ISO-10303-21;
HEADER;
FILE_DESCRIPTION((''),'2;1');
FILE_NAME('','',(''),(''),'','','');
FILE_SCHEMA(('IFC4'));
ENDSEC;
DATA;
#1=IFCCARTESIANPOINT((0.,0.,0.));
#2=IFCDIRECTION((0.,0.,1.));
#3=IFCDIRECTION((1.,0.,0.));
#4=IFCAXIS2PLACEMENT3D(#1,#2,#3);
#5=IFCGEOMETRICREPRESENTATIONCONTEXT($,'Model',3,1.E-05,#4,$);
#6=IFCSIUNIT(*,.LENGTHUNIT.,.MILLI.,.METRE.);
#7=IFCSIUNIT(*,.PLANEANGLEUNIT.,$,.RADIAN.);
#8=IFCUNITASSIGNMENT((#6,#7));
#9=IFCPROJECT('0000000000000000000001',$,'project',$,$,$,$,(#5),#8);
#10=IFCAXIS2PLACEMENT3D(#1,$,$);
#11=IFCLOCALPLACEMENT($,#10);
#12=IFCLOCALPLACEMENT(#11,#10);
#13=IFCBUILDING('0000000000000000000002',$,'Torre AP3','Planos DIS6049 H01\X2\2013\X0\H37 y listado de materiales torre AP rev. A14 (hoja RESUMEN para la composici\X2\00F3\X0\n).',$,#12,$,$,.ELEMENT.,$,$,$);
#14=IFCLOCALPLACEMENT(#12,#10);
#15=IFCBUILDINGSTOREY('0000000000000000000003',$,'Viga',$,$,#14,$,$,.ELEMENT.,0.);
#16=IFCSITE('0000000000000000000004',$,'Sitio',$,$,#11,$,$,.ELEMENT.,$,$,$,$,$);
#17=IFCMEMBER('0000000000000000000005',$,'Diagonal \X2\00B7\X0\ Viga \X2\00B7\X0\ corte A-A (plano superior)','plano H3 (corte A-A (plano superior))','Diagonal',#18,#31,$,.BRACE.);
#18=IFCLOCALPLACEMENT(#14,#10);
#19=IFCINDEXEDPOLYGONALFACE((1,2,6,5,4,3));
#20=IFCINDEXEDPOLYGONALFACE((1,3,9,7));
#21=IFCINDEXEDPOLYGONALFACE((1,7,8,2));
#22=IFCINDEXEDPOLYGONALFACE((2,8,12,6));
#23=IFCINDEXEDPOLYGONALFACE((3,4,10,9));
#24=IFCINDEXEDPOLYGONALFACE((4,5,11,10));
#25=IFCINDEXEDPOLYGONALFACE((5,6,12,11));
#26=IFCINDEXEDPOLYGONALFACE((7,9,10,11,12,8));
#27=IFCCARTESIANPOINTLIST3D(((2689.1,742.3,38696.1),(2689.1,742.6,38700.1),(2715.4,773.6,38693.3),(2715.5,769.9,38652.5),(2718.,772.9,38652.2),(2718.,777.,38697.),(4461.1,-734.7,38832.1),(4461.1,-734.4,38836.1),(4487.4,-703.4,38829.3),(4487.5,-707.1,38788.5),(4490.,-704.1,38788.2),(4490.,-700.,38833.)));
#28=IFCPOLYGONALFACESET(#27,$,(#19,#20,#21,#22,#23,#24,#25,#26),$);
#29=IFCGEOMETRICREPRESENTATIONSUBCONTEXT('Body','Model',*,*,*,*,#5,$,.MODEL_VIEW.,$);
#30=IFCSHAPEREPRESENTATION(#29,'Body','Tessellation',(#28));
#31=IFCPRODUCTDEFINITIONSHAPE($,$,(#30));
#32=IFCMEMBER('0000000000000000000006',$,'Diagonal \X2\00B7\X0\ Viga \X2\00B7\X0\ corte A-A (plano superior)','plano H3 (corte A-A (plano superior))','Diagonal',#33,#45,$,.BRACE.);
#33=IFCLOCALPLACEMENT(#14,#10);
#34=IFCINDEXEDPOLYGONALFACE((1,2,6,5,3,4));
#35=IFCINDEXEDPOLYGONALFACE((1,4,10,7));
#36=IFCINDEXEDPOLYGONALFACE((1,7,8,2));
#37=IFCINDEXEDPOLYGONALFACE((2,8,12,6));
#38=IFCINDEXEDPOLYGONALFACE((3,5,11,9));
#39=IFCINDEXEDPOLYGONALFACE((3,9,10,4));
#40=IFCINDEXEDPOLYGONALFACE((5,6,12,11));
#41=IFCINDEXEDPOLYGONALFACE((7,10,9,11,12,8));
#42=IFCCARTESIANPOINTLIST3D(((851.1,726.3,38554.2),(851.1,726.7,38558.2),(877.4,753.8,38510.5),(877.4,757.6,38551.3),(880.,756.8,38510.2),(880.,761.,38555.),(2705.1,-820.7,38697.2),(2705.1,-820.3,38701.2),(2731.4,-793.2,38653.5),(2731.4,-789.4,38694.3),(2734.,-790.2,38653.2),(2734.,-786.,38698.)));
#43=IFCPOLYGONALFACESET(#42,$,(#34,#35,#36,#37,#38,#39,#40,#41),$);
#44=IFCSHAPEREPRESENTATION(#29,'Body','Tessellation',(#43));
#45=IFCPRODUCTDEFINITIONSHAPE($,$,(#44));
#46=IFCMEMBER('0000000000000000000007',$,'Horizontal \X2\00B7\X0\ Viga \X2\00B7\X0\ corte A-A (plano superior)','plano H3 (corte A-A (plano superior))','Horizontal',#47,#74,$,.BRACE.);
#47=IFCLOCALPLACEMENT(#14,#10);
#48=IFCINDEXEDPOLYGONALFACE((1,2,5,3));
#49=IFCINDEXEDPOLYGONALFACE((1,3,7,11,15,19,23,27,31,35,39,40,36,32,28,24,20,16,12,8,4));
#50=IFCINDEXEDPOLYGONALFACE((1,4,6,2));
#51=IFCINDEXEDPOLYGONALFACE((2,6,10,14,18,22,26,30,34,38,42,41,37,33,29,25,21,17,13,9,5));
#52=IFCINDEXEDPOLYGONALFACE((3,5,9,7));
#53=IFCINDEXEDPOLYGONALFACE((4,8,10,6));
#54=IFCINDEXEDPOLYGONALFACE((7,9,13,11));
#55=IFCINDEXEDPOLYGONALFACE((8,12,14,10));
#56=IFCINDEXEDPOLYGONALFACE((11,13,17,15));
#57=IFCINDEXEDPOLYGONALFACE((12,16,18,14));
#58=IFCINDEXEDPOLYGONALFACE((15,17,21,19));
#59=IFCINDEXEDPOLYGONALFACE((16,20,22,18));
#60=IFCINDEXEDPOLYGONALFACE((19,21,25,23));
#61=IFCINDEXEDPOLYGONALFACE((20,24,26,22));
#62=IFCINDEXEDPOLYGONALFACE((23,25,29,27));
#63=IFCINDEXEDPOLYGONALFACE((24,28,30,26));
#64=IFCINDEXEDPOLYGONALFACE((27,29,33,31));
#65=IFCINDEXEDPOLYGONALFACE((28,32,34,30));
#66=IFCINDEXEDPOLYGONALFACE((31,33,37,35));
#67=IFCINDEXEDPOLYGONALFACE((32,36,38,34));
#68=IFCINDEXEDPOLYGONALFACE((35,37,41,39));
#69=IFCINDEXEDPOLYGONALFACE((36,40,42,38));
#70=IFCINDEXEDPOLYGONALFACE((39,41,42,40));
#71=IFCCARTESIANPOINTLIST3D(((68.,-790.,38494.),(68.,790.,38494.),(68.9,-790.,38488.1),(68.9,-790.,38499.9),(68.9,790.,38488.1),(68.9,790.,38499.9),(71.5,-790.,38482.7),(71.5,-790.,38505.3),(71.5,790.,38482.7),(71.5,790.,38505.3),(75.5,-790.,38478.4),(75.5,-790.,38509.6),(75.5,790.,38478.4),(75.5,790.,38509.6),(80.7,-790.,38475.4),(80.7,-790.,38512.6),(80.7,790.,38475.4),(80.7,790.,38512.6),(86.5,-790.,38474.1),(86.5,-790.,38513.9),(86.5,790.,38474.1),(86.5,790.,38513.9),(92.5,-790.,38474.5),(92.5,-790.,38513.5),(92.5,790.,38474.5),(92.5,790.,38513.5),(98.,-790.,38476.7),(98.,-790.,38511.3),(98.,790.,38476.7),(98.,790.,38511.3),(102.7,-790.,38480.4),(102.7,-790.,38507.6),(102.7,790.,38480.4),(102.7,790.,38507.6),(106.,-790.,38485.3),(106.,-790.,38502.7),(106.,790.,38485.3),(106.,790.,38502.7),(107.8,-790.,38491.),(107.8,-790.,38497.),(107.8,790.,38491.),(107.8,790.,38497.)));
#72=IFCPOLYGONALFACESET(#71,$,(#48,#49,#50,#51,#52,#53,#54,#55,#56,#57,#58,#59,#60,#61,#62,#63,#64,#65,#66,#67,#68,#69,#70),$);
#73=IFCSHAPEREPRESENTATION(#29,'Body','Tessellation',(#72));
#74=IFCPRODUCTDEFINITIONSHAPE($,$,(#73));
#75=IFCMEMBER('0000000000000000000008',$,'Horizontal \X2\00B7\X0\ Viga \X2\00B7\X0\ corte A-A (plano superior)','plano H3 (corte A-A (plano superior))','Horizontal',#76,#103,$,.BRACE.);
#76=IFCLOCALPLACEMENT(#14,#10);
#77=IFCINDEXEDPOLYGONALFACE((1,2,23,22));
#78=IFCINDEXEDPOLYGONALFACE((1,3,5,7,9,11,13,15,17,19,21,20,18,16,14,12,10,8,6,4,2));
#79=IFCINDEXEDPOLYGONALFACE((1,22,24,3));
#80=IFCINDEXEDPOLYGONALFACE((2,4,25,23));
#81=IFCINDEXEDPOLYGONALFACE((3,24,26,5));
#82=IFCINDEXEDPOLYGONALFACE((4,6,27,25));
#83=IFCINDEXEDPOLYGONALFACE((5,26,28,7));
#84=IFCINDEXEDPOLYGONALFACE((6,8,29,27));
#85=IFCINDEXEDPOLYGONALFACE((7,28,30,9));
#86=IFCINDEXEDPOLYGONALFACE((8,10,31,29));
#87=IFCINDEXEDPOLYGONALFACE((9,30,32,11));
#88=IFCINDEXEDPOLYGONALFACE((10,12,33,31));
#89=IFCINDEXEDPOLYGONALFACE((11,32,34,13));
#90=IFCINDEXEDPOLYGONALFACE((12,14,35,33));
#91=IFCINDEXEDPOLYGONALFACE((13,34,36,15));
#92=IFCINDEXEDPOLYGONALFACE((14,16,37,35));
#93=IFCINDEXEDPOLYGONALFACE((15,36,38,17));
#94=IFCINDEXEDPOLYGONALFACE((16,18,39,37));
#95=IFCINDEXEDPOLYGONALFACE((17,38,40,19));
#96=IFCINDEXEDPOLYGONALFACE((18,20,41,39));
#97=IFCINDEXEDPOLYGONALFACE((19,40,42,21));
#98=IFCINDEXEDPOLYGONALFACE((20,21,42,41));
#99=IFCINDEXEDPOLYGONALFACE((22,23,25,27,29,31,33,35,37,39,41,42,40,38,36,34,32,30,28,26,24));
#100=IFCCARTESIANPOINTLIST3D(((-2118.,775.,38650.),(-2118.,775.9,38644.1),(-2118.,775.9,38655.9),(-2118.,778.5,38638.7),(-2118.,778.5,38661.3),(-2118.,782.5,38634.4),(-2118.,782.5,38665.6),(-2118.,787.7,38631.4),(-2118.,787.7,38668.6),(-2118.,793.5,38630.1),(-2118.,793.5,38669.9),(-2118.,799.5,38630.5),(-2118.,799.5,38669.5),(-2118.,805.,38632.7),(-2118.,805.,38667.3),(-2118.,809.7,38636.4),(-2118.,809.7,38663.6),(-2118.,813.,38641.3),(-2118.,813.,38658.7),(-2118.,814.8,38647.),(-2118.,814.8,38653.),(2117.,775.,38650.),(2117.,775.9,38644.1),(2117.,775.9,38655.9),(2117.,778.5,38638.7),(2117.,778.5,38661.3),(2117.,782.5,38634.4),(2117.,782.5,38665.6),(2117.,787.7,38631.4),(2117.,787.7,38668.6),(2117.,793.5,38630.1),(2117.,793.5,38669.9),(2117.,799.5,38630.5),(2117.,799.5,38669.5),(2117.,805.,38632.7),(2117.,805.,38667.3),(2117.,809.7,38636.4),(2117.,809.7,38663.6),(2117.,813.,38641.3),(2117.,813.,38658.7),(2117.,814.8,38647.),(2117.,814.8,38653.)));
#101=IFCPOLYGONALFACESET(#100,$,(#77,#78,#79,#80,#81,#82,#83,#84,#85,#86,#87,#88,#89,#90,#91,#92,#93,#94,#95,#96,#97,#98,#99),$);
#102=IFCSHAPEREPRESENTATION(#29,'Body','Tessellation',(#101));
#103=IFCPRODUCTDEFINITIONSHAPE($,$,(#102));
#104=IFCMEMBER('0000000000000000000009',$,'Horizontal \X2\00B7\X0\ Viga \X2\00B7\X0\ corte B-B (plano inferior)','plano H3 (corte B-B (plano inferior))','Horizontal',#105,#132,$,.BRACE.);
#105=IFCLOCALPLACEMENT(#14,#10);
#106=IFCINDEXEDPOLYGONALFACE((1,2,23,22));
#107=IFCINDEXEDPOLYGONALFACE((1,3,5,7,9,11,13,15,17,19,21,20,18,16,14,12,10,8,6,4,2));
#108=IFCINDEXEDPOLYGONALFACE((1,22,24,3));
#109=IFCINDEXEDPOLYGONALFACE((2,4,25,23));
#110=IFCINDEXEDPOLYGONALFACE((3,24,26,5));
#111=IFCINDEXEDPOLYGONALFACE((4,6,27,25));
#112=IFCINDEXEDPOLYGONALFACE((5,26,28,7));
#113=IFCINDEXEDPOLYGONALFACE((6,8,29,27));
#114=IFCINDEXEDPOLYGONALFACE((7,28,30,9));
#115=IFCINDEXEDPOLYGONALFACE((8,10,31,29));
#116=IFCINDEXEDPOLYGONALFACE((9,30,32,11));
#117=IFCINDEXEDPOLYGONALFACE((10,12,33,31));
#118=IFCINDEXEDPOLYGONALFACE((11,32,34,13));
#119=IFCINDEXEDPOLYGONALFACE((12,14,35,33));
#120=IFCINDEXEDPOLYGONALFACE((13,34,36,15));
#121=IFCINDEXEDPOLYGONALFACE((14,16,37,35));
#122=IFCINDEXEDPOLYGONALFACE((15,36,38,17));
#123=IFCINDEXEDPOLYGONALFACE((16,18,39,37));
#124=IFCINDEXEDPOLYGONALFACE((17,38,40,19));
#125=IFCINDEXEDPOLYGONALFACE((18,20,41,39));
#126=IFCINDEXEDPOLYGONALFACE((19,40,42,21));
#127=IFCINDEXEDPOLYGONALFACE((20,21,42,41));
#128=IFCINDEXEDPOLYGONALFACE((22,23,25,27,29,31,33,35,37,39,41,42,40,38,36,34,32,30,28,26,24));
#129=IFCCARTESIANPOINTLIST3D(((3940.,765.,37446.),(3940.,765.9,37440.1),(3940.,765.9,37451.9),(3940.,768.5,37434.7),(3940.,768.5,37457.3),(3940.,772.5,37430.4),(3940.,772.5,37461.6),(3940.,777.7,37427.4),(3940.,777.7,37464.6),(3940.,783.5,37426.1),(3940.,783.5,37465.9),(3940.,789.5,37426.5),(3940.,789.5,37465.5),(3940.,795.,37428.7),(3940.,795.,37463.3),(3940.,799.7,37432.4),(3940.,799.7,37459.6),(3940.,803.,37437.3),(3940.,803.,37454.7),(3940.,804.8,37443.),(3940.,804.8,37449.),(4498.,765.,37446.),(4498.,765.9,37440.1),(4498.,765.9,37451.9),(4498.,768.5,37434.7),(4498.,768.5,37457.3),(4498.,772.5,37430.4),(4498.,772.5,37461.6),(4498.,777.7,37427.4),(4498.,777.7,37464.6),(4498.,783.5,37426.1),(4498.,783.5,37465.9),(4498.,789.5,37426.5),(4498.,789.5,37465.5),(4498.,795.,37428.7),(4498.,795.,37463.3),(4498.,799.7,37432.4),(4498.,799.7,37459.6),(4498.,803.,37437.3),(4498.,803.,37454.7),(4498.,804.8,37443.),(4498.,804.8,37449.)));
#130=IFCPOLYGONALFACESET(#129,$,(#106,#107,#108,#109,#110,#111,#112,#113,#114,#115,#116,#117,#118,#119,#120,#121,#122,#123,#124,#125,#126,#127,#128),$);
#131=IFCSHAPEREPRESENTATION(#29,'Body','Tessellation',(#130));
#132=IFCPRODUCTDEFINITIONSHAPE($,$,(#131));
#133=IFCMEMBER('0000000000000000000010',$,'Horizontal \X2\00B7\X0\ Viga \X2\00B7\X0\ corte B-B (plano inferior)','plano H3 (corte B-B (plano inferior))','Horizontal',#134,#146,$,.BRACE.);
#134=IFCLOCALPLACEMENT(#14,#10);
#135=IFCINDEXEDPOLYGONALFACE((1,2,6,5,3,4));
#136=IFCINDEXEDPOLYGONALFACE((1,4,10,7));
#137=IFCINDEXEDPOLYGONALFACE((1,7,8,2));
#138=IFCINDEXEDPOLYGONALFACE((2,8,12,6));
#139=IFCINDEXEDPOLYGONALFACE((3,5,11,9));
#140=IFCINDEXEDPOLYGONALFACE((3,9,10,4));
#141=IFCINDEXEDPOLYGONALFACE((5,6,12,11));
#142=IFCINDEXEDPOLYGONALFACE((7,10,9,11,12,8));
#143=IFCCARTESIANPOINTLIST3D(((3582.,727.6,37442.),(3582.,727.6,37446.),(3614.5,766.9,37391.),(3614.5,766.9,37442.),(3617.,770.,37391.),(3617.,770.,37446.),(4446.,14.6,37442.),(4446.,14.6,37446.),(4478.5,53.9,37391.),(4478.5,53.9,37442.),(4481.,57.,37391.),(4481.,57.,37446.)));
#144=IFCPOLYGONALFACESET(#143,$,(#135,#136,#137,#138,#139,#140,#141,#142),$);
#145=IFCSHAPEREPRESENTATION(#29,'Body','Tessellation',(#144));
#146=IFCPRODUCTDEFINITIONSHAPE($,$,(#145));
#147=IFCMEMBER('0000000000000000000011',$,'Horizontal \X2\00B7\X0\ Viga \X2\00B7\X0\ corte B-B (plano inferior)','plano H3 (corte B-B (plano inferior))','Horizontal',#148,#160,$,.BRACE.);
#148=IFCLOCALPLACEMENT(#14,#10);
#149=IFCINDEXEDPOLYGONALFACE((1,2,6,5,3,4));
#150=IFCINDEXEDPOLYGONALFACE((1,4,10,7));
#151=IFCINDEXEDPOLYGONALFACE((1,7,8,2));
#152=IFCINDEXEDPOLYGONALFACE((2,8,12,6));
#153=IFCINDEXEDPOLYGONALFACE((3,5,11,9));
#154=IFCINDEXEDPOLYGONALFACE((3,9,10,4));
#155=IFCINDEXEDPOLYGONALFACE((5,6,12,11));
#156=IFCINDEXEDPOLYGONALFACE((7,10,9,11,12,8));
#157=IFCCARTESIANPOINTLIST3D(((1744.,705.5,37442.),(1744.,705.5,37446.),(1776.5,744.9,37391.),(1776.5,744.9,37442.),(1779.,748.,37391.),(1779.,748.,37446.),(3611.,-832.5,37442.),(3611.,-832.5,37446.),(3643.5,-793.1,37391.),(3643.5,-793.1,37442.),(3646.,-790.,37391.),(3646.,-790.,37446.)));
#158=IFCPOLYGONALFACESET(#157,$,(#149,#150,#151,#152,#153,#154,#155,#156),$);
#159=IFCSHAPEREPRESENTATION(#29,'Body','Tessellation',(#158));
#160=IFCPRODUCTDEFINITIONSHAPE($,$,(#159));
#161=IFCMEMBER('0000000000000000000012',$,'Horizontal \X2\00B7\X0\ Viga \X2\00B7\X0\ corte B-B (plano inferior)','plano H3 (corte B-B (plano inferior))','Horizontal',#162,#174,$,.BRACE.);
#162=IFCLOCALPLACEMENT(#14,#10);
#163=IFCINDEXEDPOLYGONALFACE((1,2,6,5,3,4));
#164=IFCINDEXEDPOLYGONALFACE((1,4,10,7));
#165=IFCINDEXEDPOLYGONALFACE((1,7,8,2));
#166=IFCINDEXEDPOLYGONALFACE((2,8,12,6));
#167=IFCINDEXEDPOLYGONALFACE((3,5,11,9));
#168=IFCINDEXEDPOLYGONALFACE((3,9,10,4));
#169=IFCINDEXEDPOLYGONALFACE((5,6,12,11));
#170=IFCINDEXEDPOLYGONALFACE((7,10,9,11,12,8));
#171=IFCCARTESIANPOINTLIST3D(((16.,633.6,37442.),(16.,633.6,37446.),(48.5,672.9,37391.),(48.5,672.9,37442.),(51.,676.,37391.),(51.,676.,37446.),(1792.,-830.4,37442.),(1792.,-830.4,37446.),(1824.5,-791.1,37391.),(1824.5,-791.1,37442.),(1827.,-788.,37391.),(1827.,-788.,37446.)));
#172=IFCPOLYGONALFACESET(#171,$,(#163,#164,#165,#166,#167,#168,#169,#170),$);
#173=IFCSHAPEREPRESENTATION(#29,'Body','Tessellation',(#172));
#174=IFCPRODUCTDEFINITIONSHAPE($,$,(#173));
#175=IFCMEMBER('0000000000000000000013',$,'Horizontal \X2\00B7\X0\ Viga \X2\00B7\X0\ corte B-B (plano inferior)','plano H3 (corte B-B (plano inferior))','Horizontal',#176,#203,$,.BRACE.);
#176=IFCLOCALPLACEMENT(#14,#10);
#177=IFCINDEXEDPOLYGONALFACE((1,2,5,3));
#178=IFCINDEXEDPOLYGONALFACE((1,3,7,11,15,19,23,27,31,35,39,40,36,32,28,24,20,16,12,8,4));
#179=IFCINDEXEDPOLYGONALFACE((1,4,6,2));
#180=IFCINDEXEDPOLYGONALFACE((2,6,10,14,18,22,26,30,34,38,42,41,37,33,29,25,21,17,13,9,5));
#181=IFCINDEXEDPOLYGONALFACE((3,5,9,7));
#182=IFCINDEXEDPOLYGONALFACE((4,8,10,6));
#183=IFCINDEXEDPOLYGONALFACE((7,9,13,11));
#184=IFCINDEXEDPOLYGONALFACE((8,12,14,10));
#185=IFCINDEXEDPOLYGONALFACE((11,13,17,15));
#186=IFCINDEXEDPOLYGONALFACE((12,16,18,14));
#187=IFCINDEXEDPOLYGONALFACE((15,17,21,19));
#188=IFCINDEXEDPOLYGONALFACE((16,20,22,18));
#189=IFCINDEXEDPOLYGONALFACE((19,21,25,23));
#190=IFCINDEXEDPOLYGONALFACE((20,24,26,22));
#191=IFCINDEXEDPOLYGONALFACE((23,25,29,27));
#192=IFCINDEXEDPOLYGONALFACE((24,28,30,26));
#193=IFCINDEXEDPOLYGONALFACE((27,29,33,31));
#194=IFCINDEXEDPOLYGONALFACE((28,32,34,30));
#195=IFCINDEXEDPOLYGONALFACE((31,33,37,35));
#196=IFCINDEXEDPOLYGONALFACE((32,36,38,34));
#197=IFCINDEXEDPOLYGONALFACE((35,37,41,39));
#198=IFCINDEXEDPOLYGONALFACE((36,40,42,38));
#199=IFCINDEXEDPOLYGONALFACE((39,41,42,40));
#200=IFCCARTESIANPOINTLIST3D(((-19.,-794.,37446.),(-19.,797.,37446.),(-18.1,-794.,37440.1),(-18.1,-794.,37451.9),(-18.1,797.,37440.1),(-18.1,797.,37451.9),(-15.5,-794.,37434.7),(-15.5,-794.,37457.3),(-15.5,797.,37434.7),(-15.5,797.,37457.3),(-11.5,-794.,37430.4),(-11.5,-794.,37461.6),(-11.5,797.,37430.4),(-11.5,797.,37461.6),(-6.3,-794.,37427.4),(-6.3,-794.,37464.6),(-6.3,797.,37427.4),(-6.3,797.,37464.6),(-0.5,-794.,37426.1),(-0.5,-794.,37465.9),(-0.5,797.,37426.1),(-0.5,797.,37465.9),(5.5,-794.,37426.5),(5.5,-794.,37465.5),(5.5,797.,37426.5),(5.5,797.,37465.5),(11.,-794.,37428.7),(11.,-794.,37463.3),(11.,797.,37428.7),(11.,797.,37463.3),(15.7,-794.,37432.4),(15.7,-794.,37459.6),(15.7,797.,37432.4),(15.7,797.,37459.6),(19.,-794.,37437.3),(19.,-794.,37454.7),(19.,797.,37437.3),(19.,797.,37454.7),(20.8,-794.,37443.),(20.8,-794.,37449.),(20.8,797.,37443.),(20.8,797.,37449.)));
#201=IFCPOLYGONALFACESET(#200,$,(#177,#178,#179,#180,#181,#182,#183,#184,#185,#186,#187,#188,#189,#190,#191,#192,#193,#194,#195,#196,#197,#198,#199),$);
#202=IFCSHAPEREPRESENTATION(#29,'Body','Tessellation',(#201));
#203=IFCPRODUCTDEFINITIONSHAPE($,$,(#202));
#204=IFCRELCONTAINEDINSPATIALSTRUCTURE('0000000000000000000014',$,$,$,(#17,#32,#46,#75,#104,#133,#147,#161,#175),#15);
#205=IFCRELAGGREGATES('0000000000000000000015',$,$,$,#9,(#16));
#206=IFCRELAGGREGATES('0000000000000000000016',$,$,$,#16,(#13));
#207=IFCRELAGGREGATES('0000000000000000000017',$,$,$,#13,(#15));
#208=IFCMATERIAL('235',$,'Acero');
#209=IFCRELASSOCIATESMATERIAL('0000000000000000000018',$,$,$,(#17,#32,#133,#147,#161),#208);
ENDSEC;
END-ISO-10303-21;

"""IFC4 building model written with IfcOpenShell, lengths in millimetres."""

from ifc_helpers import new_model, si_unit, frame, frame_2d, origin, origin_with_axes, place, context, subcontext, project, spatial, circle, l_section, extrude, material, element, save


model = new_model("IFC4")

# Units and contexts
model_context = context("Model", 3, precision=1e-05, world=origin_with_axes())
body_context = subcontext(model_context, "Body", "Model", "MODEL_VIEW")
ifc_project = project(units=[si_unit("LENGTHUNIT", "METRE", prefix="MILLI"), si_unit("PLANEANGLEUNIT", "RADIAN")], contexts=[model_context])

# Site, building, storey
site_placement = place(None, origin())
site = spatial("IfcSite", under=ifc_project, at=site_placement, Name="Sitio", CompositionType="ELEMENT")
building_placement = place(site_placement, origin())
building = spatial("IfcBuilding", under=site, at=building_placement, Name="Torre AP3", Description="Planos DIS6049 H01–H37 y listado de materiales torre AP rev. A14 (hoja RESUMEN para la composición).", CompositionType="ELEMENT")
storey_placement = place(building_placement, origin())
storey = spatial("IfcBuildingStorey", under=building, at=storey_placement, Name="Viga", CompositionType="ELEMENT", Elevation=0.0)

# Members
ifc_material = material(Name="235", Category="Acero")
member_1_placement = place(storey_placement, frame((2718.0, 777.0, 38697.0), z_axis=(0.766819, -0.63916, 0.058853), x_axis=(-0.641863, -0.763726, 0.06881)))
element("IfcMember", 1, at=member_1_placement, inside=storey, material=ifc_material, Name="Diagonal · Viga · corte A-A (plano superior)", Description="plano H3 (corte A-A (plano superior))", ObjectType="Diagonal", PredefinedType="BRACE", context=body_context, shape_type="SweptSolid", body=[
    extrude(l_section(Depth=45.0, Width=45.0, Thickness=4.0, at=frame_2d((22.5, 22.5))), None, (0.0, 0.0, 1.0), 2310.8),
])
member_2_placement = place(storey_placement, frame((880.0, 761.0, 38555.0), z_axis=(0.766471, -0.639553, 0.059118), x_axis=(-0.642279, -0.763125, 0.071545)))
element("IfcMember", 2, at=member_2_placement, inside=storey, material=ifc_material, Name="Diagonal · Viga · corte A-A (plano superior)", Description="plano H3 (corte A-A (plano superior))", ObjectType="Diagonal", PredefinedType="BRACE", context=body_context, shape_type="SweptSolid", body=[
    extrude(l_section(Depth=45.0, Width=45.0, Thickness=4.0, at=frame_2d((22.5, 22.5))), None, (0.0, 0.0, 1.0), 2418.9),
])
member_3_placement = place(storey_placement, frame((88.0, 790.0, 38494.0), z_axis=(0.0, -1.0, 0.0), x_axis=(-1.0, 0.0, 0.0)))
element("IfcMember", 3, at=member_3_placement, inside=storey, Name="Horizontal · Viga · corte A-A (plano superior)", Description="plano H3 (corte A-A (plano superior))", ObjectType="Horizontal", PredefinedType="BRACE", context=body_context, shape_type="SweptSolid", body=[
    extrude(circle(Radius=20.0), None, (0.0, 0.0, 1.0), 1580.0),
])
member_4_placement = place(storey_placement, frame((2117.0, 795.0, 38650.0), z_axis=(-1.0, 0.0, 0.0), x_axis=(0.0, -1.0, 0.0)))
element("IfcMember", 4, at=member_4_placement, inside=storey, Name="Horizontal · Viga · corte A-A (plano superior)", Description="plano H3 (corte A-A (plano superior))", ObjectType="Horizontal", PredefinedType="BRACE", context=body_context, shape_type="SweptSolid", body=[
    extrude(circle(Radius=20.0), None, (0.0, 0.0, 1.0), 4235.0),
])
member_5_placement = place(storey_placement, frame((3940.0, 785.0, 37446.0), z_axis=(1.0, 0.0, 0.0), x_axis=(0.0, -1.0, 0.0)))
element("IfcMember", 5, at=member_5_placement, inside=storey, Name="Horizontal · Viga · corte B-B (plano inferior)", Description="plano H3 (corte B-B (plano inferior))", ObjectType="Horizontal", PredefinedType="BRACE", context=body_context, shape_type="SweptSolid", body=[
    extrude(circle(Radius=20.0), None, (0.0, 0.0, 1.0), 558.0),
])
member_6_placement = place(storey_placement, frame((3617.0, 770.0, 37446.0), z_axis=(0.771286, -0.636489, 0.0), x_axis=(-0.636489, -0.771286, 0.0)))
element("IfcMember", 6, at=member_6_placement, inside=storey, material=ifc_material, Name="Horizontal · Viga · corte B-B (plano inferior)", Description="plano H3 (corte B-B (plano inferior))", ObjectType="Horizontal", PredefinedType="BRACE", context=body_context, shape_type="SweptSolid", body=[
    extrude(l_section(Depth=55.0, Width=55.0, Thickness=4.0, at=frame_2d((27.5, 27.5))), None, (0.0, 0.0, 1.0), 1120.2),
])
member_7_placement = place(storey_placement, frame((1779.0, 748.0, 37446.0), z_axis=(0.771835, -0.635823, 0.0), x_axis=(-0.635823, -0.771835, 0.0)))
element("IfcMember", 7, at=member_7_placement, inside=storey, material=ifc_material, Name="Horizontal · Viga · corte B-B (plano inferior)", Description="plano H3 (corte B-B (plano inferior))", ObjectType="Horizontal", PredefinedType="BRACE", context=body_context, shape_type="SweptSolid", body=[
    extrude(l_section(Depth=55.0, Width=55.0, Thickness=4.0, at=frame_2d((27.5, 27.5))), None, (0.0, 0.0, 1.0), 2418.9),
])
member_8_placement = place(storey_placement, frame((51.0, 676.0, 37446.0), z_axis=(0.771629, -0.636073, 0.0), x_axis=(-0.636073, -0.771629, 0.0)))
element("IfcMember", 8, at=member_8_placement, inside=storey, material=ifc_material, Name="Horizontal · Viga · corte B-B (plano inferior)", Description="plano H3 (corte B-B (plano inferior))", ObjectType="Horizontal", PredefinedType="BRACE", context=body_context, shape_type="SweptSolid", body=[
    extrude(l_section(Depth=55.0, Width=55.0, Thickness=4.0, at=frame_2d((27.5, 27.5))), None, (0.0, 0.0, 1.0), 2301.6),
])
member_9_placement = place(storey_placement, frame((1.0, 797.0, 37446.0), z_axis=(0.0, -1.0, 0.0), x_axis=(-1.0, 0.0, 0.0)))
element("IfcMember", 9, at=member_9_placement, inside=storey, Name="Horizontal · Viga · corte B-B (plano inferior)", Description="plano H3 (corte B-B (plano inferior))", ObjectType="Horizontal", PredefinedType="BRACE", context=body_context, shape_type="SweptSolid", body=[
    extrude(circle(Radius=20.0), None, (0.0, 0.0, 1.0), 1591.0),
])

save(model, "model.ifc")
